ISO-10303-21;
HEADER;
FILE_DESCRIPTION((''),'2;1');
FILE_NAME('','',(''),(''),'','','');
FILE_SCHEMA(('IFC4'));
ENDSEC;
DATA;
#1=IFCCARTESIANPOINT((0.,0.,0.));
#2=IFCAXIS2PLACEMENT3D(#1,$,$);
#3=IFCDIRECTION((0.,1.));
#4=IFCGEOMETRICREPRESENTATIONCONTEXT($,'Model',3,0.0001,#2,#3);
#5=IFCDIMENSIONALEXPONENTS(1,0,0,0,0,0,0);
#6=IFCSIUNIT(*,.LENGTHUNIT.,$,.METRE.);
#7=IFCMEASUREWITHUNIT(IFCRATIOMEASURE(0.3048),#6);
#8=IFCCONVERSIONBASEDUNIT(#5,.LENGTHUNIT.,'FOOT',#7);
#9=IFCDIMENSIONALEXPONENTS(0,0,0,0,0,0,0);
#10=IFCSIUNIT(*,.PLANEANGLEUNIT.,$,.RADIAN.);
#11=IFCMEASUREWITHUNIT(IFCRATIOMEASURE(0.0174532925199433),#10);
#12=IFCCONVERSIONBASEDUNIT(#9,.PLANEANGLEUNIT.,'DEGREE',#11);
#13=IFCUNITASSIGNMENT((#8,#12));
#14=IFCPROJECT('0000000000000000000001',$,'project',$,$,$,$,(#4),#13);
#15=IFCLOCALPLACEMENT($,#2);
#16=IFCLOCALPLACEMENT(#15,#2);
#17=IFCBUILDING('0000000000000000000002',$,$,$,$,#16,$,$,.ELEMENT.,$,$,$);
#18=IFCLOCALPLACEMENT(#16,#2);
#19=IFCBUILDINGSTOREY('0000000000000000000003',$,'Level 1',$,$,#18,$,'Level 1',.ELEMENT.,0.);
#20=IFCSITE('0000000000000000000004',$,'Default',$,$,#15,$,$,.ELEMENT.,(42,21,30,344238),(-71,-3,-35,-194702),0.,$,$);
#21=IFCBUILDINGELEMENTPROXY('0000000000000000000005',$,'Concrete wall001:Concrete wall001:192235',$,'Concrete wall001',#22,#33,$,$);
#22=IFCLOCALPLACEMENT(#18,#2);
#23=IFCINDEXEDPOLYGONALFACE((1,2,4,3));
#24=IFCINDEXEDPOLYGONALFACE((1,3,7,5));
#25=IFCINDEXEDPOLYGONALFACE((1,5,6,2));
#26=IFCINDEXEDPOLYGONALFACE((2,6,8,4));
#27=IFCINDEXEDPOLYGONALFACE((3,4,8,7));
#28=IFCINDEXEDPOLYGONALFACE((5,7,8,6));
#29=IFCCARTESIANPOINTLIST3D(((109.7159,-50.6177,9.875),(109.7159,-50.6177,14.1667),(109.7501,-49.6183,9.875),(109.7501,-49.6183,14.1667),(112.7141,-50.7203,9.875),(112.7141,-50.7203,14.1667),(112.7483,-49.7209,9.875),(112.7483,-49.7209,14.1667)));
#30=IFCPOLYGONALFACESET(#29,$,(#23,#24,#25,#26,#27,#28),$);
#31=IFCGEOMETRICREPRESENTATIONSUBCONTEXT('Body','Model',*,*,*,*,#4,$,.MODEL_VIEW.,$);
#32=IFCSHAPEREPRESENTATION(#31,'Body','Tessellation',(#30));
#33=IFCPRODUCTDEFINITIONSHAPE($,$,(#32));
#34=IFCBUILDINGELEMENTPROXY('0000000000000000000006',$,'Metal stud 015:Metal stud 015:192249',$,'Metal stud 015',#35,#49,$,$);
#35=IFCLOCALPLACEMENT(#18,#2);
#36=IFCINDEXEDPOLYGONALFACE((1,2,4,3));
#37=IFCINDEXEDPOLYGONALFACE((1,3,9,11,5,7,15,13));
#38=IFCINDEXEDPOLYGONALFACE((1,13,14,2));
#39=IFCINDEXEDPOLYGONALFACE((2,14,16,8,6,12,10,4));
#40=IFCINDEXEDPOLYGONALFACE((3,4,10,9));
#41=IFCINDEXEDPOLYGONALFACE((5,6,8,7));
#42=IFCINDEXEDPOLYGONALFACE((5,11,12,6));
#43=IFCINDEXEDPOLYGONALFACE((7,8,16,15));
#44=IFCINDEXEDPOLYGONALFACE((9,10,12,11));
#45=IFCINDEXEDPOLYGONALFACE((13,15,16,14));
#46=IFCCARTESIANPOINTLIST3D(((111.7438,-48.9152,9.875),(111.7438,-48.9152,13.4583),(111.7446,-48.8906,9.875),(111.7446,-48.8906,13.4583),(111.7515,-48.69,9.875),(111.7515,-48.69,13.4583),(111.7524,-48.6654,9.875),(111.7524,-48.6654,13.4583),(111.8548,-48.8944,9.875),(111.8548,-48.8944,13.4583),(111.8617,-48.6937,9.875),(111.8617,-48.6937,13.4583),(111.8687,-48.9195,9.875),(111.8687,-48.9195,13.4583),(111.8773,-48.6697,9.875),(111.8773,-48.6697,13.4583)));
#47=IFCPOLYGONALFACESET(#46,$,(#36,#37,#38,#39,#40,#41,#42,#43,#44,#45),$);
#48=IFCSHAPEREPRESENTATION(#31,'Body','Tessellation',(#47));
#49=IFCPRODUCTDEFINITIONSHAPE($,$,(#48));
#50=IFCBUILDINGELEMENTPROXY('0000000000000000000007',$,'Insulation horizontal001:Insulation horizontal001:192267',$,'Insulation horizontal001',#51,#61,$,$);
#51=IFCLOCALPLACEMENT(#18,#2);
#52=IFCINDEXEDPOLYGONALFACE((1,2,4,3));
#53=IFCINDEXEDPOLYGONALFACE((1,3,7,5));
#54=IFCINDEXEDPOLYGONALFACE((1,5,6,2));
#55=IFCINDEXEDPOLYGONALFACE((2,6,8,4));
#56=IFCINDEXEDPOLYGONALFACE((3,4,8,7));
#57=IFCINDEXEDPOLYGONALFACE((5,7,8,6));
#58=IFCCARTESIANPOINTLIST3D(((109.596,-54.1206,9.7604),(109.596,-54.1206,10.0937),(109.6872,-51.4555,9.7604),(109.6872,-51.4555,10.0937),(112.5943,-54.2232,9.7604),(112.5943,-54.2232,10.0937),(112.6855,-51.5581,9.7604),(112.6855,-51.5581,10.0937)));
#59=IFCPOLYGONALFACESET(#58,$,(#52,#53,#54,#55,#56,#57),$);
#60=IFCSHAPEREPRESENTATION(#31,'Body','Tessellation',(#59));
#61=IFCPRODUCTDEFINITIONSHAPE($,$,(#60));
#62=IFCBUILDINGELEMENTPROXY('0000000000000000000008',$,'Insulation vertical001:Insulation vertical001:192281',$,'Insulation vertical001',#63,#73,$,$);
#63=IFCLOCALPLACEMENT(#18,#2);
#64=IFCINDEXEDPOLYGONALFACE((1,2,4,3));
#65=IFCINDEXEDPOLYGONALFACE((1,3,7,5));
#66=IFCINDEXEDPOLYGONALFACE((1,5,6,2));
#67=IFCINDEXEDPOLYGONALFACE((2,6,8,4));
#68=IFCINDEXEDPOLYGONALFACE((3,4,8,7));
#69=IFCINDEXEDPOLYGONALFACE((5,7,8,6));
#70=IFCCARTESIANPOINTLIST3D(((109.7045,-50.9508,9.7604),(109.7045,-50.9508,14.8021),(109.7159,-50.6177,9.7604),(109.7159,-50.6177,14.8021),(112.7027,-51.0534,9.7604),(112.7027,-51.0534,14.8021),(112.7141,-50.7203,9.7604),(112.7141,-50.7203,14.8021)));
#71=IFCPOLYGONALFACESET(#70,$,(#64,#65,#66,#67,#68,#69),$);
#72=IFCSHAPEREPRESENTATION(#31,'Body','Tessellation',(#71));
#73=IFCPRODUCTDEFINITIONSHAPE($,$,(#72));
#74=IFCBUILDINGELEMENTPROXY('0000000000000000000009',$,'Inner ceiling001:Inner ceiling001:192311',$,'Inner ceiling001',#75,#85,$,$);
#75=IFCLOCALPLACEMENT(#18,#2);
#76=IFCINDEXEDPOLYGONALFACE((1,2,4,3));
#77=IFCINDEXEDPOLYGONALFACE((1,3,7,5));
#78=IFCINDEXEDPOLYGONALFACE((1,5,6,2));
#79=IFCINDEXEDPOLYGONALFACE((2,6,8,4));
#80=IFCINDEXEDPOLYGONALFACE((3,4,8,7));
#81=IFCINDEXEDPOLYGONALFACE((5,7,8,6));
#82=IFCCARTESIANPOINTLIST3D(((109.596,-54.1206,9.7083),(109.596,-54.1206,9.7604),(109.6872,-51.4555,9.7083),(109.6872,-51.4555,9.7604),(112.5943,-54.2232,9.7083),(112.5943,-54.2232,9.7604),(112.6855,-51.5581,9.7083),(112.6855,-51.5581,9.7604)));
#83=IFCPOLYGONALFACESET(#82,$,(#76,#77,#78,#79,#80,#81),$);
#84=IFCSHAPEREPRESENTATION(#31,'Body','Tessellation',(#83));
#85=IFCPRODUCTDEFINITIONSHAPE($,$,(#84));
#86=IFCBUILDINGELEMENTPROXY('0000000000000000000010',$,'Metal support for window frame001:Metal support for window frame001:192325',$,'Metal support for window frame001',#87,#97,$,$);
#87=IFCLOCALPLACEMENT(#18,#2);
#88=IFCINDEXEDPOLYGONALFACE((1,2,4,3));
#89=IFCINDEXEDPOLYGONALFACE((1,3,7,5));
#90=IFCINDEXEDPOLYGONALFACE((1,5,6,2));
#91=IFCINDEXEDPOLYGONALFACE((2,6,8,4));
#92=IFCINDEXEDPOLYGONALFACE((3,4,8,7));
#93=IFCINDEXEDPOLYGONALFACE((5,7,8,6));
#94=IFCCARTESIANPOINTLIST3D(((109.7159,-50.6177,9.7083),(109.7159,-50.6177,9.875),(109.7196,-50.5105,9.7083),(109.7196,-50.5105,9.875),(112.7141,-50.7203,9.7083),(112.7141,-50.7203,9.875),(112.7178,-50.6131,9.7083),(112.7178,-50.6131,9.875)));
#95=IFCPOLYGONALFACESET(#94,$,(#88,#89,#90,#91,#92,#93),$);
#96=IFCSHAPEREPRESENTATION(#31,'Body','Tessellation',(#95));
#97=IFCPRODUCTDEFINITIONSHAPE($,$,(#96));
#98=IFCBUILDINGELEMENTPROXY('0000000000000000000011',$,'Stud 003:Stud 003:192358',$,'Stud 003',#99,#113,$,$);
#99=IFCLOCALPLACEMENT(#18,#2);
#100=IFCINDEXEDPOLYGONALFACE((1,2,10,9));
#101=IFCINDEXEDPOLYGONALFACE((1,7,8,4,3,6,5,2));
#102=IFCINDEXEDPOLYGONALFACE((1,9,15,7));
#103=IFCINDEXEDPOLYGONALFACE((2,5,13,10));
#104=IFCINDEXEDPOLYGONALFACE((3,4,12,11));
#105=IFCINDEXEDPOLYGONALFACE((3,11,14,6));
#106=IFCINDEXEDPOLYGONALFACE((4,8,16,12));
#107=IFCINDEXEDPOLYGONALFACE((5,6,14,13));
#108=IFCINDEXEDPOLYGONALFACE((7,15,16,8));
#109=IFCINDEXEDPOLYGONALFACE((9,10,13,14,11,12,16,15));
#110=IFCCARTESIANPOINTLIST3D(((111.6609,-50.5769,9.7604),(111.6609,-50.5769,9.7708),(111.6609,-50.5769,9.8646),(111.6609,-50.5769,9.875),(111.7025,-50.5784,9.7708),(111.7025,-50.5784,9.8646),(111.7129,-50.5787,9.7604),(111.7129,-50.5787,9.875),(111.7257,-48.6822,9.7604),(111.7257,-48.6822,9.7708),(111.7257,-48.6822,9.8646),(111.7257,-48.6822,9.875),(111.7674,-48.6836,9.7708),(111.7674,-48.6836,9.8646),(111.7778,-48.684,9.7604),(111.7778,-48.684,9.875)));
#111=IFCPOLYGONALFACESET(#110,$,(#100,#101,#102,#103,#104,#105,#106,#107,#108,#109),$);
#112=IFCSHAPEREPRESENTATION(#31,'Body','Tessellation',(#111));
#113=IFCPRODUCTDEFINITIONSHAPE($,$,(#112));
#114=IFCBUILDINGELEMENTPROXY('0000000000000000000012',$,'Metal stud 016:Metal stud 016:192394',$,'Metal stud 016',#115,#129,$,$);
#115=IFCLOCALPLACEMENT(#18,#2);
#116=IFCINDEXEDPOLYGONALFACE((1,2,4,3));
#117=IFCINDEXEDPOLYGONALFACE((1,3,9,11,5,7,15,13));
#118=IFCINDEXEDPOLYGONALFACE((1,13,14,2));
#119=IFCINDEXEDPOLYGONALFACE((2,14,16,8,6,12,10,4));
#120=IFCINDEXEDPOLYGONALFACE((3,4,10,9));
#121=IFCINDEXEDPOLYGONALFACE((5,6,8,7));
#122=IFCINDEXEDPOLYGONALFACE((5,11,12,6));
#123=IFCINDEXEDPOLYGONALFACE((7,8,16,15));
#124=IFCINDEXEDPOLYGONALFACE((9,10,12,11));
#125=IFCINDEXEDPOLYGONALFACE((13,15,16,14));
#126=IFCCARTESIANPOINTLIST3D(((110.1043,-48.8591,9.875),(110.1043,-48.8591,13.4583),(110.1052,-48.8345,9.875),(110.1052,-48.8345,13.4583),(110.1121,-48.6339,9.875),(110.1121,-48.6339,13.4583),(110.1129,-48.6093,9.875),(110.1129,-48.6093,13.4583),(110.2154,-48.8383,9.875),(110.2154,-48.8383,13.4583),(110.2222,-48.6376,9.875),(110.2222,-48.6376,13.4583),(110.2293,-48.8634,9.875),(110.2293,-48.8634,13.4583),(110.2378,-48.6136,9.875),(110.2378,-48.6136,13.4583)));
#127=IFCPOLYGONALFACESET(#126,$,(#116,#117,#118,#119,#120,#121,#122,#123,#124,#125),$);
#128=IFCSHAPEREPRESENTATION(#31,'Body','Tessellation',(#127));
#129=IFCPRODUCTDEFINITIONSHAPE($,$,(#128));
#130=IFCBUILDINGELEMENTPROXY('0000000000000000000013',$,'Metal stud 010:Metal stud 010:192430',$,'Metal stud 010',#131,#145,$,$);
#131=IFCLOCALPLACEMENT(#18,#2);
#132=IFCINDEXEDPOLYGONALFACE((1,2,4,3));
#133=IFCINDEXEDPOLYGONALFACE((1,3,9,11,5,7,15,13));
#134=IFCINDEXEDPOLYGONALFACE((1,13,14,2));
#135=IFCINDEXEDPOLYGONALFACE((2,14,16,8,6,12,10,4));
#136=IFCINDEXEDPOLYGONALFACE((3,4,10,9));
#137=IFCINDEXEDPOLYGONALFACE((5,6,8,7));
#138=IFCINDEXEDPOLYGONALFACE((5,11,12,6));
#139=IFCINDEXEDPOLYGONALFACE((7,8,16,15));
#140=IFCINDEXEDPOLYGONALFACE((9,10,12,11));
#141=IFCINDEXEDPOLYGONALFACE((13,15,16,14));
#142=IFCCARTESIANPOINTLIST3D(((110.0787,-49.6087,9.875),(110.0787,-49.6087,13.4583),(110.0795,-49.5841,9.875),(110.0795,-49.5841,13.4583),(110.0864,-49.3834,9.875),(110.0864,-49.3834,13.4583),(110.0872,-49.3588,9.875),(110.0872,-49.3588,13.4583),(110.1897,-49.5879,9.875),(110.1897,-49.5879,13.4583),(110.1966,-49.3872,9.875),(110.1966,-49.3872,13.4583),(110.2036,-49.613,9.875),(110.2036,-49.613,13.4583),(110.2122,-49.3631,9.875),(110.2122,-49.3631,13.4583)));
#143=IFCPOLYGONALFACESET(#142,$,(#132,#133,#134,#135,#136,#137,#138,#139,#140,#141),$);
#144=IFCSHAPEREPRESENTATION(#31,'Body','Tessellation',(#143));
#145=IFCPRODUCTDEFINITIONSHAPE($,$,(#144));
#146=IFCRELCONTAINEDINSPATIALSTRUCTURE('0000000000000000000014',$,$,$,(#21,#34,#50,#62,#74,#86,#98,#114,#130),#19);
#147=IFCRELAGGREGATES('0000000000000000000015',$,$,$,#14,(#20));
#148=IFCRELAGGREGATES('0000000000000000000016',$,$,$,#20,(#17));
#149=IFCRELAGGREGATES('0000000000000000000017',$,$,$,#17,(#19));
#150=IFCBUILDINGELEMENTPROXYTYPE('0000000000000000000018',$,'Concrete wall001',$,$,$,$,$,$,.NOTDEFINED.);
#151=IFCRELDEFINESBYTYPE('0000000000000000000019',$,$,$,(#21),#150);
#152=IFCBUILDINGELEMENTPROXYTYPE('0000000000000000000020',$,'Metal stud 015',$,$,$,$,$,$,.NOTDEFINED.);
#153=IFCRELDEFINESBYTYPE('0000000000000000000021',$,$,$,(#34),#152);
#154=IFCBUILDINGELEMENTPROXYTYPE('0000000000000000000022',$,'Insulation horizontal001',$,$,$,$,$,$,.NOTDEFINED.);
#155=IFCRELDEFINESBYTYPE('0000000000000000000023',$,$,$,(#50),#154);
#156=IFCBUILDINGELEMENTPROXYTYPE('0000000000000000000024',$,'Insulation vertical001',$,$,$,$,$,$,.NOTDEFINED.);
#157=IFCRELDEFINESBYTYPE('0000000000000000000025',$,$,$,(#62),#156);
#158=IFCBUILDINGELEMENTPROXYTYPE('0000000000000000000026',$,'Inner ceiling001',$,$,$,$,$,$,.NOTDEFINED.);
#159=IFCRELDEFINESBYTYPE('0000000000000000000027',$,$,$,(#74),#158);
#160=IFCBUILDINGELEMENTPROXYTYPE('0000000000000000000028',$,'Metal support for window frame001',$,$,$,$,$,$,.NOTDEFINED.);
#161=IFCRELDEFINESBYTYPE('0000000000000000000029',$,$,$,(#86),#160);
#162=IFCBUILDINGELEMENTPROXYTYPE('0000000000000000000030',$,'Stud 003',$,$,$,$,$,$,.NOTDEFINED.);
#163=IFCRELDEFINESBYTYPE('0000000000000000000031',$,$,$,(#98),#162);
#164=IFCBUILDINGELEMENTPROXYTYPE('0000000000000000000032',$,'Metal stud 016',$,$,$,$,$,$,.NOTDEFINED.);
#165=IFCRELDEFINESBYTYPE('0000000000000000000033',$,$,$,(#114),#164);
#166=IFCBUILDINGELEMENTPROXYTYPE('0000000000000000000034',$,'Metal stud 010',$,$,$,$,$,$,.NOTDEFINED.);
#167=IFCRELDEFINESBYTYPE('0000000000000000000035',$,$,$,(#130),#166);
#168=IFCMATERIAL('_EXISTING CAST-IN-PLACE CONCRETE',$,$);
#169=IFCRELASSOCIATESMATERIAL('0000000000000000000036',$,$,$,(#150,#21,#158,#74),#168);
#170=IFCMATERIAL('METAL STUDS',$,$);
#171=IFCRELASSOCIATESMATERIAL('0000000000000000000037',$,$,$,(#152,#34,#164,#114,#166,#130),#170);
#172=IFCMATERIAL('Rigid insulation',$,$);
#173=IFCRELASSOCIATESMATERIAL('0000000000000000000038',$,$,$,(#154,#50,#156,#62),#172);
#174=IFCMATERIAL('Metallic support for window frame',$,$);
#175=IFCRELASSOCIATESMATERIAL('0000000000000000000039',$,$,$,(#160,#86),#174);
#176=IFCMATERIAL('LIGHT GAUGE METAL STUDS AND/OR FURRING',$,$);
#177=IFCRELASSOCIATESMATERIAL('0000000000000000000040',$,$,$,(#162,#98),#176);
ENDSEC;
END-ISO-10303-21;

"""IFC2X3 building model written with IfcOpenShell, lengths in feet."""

from ifc_helpers import new_model, entity, si_unit, converted_unit, direction, frame, frame_2d, origin, origin_2d_with_axis, place, context, subcontext, project, spatial, polyline, rectangle, outline, extrude, source, transform, mapped, material, type_object, type_shapes, element, save


model = new_model("IFC2X3")

# Units and contexts
model_context = context("Model", 3, precision=0.0001, world=origin(), true_north=direction((0.0, 1.0)))
body_context = subcontext(model_context, "Body", "Model", "MODEL_VIEW")
ifc_project = project(units=[converted_unit("LENGTHUNIT", "FOOT", entity("IfcRatioMeasure", 0.3048), si_unit("LENGTHUNIT", "METRE"), dimensions=[1, 0, 0, 0, 0, 0, 0]), converted_unit("PLANEANGLEUNIT", "DEGREE", entity("IfcRatioMeasure", 0.0174532925199433), si_unit("PLANEANGLEUNIT", "RADIAN"), dimensions=[0, 0, 0, 0, 0, 0, 0])], contexts=[model_context])

# Site, building, storey
site_placement = place(None, origin())
site = spatial("IfcSite", under=ifc_project, at=site_placement, Name="Default", CompositionType="ELEMENT", RefLatitude=(42, 21, 30, 344238), RefLongitude=(-71, -3, -35, -194702), RefElevation=0.0)
building_placement = place(site_placement, origin())
building = spatial("IfcBuilding", under=site, at=building_placement, CompositionType="ELEMENT")
storey_placement = place(building_placement, origin())
storey = spatial("IfcBuildingStorey", under=building, at=storey_placement, Name="Level 1", LongName="Level 1", CompositionType="ELEMENT", Elevation=0.0)

# Building element proxies
ifc_material_1 = material(Name="_EXISTING CAST-IN-PLACE CONCRETE")
building_element_proxy_type_1 = type_object("IfcBuildingElementProxyType", Name="Concrete wall001", PredefinedType="NOTDEFINED", material=ifc_material_1)
shared_shape_1 = source(origin(), body_context, "Body", "SweptSolid", [
    extrude(rectangle(XDim=3.0, YDim=1.0, at=origin_2d_with_axis()), frame((111.2321, -50.1693, 9.875), z_axis=(0.0, 0.0, 1.0), x_axis=(-0.999415, 0.034202, 0.0)), (0.0, 0.0, 1.0), 4.2917),
])
type_shapes(building_element_proxy_type_1, [shared_shape_1])
proxy_1_placement = place(storey_placement, origin())
element("IfcBuildingElementProxy", 1, at=proxy_1_placement, inside=storey, type_object=building_element_proxy_type_1, material=ifc_material_1, Name="Concrete wall001:Concrete wall001:192235", ObjectType="Concrete wall001", context=body_context, shape_type="MappedRepresentation", body=[
    mapped(shared_shape_1, transform((0.0, 0.0, 0.0), scale=1.0)),
])
ifc_material_2 = material(Name="METAL STUDS")
building_element_proxy_type_2 = type_object("IfcBuildingElementProxyType", Name="Metal stud 015", PredefinedType="NOTDEFINED", material=ifc_material_2)
shared_shape_2 = source(origin(), body_context, "Body", "SweptSolid", [
    extrude(outline(polyline([(-0.0662, -0.125), (0.0588, -0.125), (0.0588, -0.1004), (-0.0514, -0.1004), (-0.0514, 0.1004), (0.0588, 0.1004), (0.0588, 0.125), (-0.0662, 0.125), (-0.0662, -0.125)])), frame((111.8069, -48.7923, 9.875), z_axis=(0.0, 0.0, 1.0), x_axis=(-0.999415, 0.034202, 0.0)), (0.0, 0.0, 1.0), 3.5833),
])
type_shapes(building_element_proxy_type_2, [shared_shape_2])
proxy_2_placement = place(storey_placement, origin())
element("IfcBuildingElementProxy", 2, at=proxy_2_placement, inside=storey, type_object=building_element_proxy_type_2, material=ifc_material_2, Name="Metal stud 015:Metal stud 015:192249", ObjectType="Metal stud 015", context=body_context, shape_type="MappedRepresentation", body=[
    mapped(shared_shape_2, transform((0.0, 0.0, 0.0), scale=1.0)),
])
ifc_material_3 = material(Name="Rigid insulation")
building_element_proxy_type_3 = type_object("IfcBuildingElementProxyType", Name="Insulation horizontal001", PredefinedType="NOTDEFINED", material=ifc_material_3)
shared_shape_3 = source(origin(), body_context, "Body", "SweptSolid", [
    extrude(rectangle(XDim=3.0, YDim=2.6667, at=origin_2d_with_axis()), frame((111.1407, -52.8394, 9.7604), z_axis=(0.0, 0.0, 1.0), x_axis=(-0.999415, 0.034202, 0.0)), (0.0, 0.0, 1.0), 0.3333),
])
type_shapes(building_element_proxy_type_3, [shared_shape_3])
proxy_3_placement = place(storey_placement, origin())
element("IfcBuildingElementProxy", 3, at=proxy_3_placement, inside=storey, type_object=building_element_proxy_type_3, material=ifc_material_3, Name="Insulation horizontal001:Insulation horizontal001:192267", ObjectType="Insulation horizontal001", context=body_context, shape_type="MappedRepresentation", body=[
    mapped(shared_shape_3, transform((0.0, 0.0, 0.0), scale=1.0)),
])
building_element_proxy_type_4 = type_object("IfcBuildingElementProxyType", Name="Insulation vertical001", PredefinedType="NOTDEFINED", material=ifc_material_3)
shared_shape_4 = source(origin(), body_context, "Body", "SweptSolid", [
    extrude(rectangle(XDim=3.0, YDim=0.3333, at=frame_2d((0.0, 0.0), x_axis=(1.0, 0.0))), frame((111.2093, -50.8356, 9.7604), z_axis=(0.0, 0.0, 1.0), x_axis=(-0.999415, 0.034202, 0.0)), (0.0, 0.0, 1.0), 5.0417),
])
type_shapes(building_element_proxy_type_4, [shared_shape_4])
proxy_4_placement = place(storey_placement, origin())
element("IfcBuildingElementProxy", 4, at=proxy_4_placement, inside=storey, type_object=building_element_proxy_type_4, material=ifc_material_3, Name="Insulation vertical001:Insulation vertical001:192281", ObjectType="Insulation vertical001", context=body_context, shape_type="MappedRepresentation", body=[
    mapped(shared_shape_4, transform((0.0, 0.0, 0.0), scale=1.0)),
])
building_element_proxy_type_5 = type_object("IfcBuildingElementProxyType", Name="Inner ceiling001", PredefinedType="NOTDEFINED", material=ifc_material_1)
shared_shape_5 = source(origin(), body_context, "Body", "SweptSolid", [
    extrude(rectangle(XDim=3.0, YDim=2.6667, at=origin_2d_with_axis()), frame((111.1407, -52.8394, 9.7083), z_axis=(0.0, 0.0, 1.0), x_axis=(-0.999415, 0.034202, 0.0)), (0.0, 0.0, 1.0), 0.0521),
])
type_shapes(building_element_proxy_type_5, [shared_shape_5])
proxy_5_placement = place(storey_placement, origin())
element("IfcBuildingElementProxy", 5, at=proxy_5_placement, inside=storey, type_object=building_element_proxy_type_5, material=ifc_material_1, Name="Inner ceiling001:Inner ceiling001:192311", ObjectType="Inner ceiling001", context=body_context, shape_type="MappedRepresentation", body=[
    mapped(shared_shape_5, transform((0.0, 0.0, 0.0), scale=1.0)),
])
ifc_material_4 = material(Name="Metallic support for window frame")
building_element_proxy_type_6 = type_object("IfcBuildingElementProxyType", Name="Metal support for window frame001", PredefinedType="NOTDEFINED", material=ifc_material_4)
shared_shape_6 = source(origin(), body_context, "Body", "SweptSolid", [
    extrude(rectangle(XDim=3.0, YDim=0.1073, at=frame_2d((0.0, 0.0), x_axis=(1.0, 0.0))), frame((111.2168, -50.6154, 9.7083), z_axis=(0.0, 0.0, 1.0), x_axis=(-0.999415, 0.034202, 0.0)), (0.0, 0.0, 1.0), 0.1667),
])
type_shapes(building_element_proxy_type_6, [shared_shape_6])
proxy_6_placement = place(storey_placement, origin())
element("IfcBuildingElementProxy", 6, at=proxy_6_placement, inside=storey, type_object=building_element_proxy_type_6, material=ifc_material_4, Name="Metal support for window frame001:Metal support for window frame001:192325", ObjectType="Metal support for window frame001", context=body_context, shape_type="MappedRepresentation", body=[
    mapped(shared_shape_6, transform((0.0, 0.0, 0.0), scale=1.0)),
])
ifc_material_5 = material(Name="LIGHT GAUGE METAL STUDS AND/OR FURRING")
building_element_proxy_type_7 = type_object("IfcBuildingElementProxyType", Name="Stud 003", PredefinedType="NOTDEFINED", material=ifc_material_5)
shared_shape_7 = source(origin(), body_context, "Body", "SweptSolid", [
    extrude(outline(polyline([(-0.0286, -0.0573), (0.0234, -0.0573), (0.0234, -0.0469), (-0.0182, -0.0469), (-0.0182, 0.0469), (0.0234, 0.0469), (0.0234, 0.0573), (-0.0286, 0.0573), (-0.0286, -0.0573)])), frame((111.6843, -50.5777, 9.8177), z_axis=(0.034202, 0.999415, 0.0), x_axis=(-0.999415, 0.034202, 0.0)), (0.0, 0.0, 1.0), 1.8958),
])
type_shapes(building_element_proxy_type_7, [shared_shape_7])
proxy_7_placement = place(storey_placement, origin())
element("IfcBuildingElementProxy", 7, at=proxy_7_placement, inside=storey, type_object=building_element_proxy_type_7, material=ifc_material_5, Name="Stud 003:Stud 003:192358", ObjectType="Stud 003", context=body_context, shape_type="MappedRepresentation", body=[
    mapped(shared_shape_7, transform((0.0, 0.0, 0.0), scale=1.0)),
])
building_element_proxy_type_8 = type_object("IfcBuildingElementProxyType", Name="Metal stud 016", PredefinedType="NOTDEFINED", material=ifc_material_2)
shared_shape_8 = source(origin(), body_context, "Body", "SweptSolid", [
    extrude(outline(polyline([(-0.0662, -0.125), (0.0588, -0.125), (0.0588, -0.1004), (-0.0514, -0.1004), (-0.0514, 0.1004), (0.0588, 0.1004), (0.0588, 0.125), (-0.0662, 0.125), (-0.0662, -0.125)])), frame((110.1674, -48.7362, 9.875), z_axis=(0.0, 0.0, 1.0), x_axis=(-0.999415, 0.034202, 0.0)), (0.0, 0.0, 1.0), 3.5833),
])
type_shapes(building_element_proxy_type_8, [shared_shape_8])
proxy_8_placement = place(storey_placement, origin())
element("IfcBuildingElementProxy", 8, at=proxy_8_placement, inside=storey, type_object=building_element_proxy_type_8, material=ifc_material_2, Name="Metal stud 016:Metal stud 016:192394", ObjectType="Metal stud 016", context=body_context, shape_type="MappedRepresentation", body=[
    mapped(shared_shape_8, transform((0.0, 0.0, 0.0), scale=1.0)),
])
building_element_proxy_type_9 = type_object("IfcBuildingElementProxyType", Name="Metal stud 010", PredefinedType="NOTDEFINED", material=ifc_material_2)
shared_shape_9 = source(origin(), body_context, "Body", "SweptSolid", [
    extrude(outline(polyline([(-0.0662, -0.125), (0.0588, -0.125), (0.0588, -0.1004), (-0.0514, -0.1004), (-0.0514, 0.1004), (0.0588, 0.1004), (0.0588, 0.125), (-0.0662, 0.125), (-0.0662, -0.125)])), frame((110.1417, -49.4858, 9.875), z_axis=(0.0, 0.0, 1.0), x_axis=(-0.999415, 0.034202, 0.0)), (0.0, 0.0, 1.0), 3.5833),
])
type_shapes(building_element_proxy_type_9, [shared_shape_9])
proxy_9_placement = place(storey_placement, origin())
element("IfcBuildingElementProxy", 9, at=proxy_9_placement, inside=storey, type_object=building_element_proxy_type_9, material=ifc_material_2, Name="Metal stud 010:Metal stud 010:192430", ObjectType="Metal stud 010", context=body_context, shape_type="MappedRepresentation", body=[
    mapped(shared_shape_9, transform((0.0, 0.0, 0.0), scale=1.0)),
])

save(model, "model.ifc")
